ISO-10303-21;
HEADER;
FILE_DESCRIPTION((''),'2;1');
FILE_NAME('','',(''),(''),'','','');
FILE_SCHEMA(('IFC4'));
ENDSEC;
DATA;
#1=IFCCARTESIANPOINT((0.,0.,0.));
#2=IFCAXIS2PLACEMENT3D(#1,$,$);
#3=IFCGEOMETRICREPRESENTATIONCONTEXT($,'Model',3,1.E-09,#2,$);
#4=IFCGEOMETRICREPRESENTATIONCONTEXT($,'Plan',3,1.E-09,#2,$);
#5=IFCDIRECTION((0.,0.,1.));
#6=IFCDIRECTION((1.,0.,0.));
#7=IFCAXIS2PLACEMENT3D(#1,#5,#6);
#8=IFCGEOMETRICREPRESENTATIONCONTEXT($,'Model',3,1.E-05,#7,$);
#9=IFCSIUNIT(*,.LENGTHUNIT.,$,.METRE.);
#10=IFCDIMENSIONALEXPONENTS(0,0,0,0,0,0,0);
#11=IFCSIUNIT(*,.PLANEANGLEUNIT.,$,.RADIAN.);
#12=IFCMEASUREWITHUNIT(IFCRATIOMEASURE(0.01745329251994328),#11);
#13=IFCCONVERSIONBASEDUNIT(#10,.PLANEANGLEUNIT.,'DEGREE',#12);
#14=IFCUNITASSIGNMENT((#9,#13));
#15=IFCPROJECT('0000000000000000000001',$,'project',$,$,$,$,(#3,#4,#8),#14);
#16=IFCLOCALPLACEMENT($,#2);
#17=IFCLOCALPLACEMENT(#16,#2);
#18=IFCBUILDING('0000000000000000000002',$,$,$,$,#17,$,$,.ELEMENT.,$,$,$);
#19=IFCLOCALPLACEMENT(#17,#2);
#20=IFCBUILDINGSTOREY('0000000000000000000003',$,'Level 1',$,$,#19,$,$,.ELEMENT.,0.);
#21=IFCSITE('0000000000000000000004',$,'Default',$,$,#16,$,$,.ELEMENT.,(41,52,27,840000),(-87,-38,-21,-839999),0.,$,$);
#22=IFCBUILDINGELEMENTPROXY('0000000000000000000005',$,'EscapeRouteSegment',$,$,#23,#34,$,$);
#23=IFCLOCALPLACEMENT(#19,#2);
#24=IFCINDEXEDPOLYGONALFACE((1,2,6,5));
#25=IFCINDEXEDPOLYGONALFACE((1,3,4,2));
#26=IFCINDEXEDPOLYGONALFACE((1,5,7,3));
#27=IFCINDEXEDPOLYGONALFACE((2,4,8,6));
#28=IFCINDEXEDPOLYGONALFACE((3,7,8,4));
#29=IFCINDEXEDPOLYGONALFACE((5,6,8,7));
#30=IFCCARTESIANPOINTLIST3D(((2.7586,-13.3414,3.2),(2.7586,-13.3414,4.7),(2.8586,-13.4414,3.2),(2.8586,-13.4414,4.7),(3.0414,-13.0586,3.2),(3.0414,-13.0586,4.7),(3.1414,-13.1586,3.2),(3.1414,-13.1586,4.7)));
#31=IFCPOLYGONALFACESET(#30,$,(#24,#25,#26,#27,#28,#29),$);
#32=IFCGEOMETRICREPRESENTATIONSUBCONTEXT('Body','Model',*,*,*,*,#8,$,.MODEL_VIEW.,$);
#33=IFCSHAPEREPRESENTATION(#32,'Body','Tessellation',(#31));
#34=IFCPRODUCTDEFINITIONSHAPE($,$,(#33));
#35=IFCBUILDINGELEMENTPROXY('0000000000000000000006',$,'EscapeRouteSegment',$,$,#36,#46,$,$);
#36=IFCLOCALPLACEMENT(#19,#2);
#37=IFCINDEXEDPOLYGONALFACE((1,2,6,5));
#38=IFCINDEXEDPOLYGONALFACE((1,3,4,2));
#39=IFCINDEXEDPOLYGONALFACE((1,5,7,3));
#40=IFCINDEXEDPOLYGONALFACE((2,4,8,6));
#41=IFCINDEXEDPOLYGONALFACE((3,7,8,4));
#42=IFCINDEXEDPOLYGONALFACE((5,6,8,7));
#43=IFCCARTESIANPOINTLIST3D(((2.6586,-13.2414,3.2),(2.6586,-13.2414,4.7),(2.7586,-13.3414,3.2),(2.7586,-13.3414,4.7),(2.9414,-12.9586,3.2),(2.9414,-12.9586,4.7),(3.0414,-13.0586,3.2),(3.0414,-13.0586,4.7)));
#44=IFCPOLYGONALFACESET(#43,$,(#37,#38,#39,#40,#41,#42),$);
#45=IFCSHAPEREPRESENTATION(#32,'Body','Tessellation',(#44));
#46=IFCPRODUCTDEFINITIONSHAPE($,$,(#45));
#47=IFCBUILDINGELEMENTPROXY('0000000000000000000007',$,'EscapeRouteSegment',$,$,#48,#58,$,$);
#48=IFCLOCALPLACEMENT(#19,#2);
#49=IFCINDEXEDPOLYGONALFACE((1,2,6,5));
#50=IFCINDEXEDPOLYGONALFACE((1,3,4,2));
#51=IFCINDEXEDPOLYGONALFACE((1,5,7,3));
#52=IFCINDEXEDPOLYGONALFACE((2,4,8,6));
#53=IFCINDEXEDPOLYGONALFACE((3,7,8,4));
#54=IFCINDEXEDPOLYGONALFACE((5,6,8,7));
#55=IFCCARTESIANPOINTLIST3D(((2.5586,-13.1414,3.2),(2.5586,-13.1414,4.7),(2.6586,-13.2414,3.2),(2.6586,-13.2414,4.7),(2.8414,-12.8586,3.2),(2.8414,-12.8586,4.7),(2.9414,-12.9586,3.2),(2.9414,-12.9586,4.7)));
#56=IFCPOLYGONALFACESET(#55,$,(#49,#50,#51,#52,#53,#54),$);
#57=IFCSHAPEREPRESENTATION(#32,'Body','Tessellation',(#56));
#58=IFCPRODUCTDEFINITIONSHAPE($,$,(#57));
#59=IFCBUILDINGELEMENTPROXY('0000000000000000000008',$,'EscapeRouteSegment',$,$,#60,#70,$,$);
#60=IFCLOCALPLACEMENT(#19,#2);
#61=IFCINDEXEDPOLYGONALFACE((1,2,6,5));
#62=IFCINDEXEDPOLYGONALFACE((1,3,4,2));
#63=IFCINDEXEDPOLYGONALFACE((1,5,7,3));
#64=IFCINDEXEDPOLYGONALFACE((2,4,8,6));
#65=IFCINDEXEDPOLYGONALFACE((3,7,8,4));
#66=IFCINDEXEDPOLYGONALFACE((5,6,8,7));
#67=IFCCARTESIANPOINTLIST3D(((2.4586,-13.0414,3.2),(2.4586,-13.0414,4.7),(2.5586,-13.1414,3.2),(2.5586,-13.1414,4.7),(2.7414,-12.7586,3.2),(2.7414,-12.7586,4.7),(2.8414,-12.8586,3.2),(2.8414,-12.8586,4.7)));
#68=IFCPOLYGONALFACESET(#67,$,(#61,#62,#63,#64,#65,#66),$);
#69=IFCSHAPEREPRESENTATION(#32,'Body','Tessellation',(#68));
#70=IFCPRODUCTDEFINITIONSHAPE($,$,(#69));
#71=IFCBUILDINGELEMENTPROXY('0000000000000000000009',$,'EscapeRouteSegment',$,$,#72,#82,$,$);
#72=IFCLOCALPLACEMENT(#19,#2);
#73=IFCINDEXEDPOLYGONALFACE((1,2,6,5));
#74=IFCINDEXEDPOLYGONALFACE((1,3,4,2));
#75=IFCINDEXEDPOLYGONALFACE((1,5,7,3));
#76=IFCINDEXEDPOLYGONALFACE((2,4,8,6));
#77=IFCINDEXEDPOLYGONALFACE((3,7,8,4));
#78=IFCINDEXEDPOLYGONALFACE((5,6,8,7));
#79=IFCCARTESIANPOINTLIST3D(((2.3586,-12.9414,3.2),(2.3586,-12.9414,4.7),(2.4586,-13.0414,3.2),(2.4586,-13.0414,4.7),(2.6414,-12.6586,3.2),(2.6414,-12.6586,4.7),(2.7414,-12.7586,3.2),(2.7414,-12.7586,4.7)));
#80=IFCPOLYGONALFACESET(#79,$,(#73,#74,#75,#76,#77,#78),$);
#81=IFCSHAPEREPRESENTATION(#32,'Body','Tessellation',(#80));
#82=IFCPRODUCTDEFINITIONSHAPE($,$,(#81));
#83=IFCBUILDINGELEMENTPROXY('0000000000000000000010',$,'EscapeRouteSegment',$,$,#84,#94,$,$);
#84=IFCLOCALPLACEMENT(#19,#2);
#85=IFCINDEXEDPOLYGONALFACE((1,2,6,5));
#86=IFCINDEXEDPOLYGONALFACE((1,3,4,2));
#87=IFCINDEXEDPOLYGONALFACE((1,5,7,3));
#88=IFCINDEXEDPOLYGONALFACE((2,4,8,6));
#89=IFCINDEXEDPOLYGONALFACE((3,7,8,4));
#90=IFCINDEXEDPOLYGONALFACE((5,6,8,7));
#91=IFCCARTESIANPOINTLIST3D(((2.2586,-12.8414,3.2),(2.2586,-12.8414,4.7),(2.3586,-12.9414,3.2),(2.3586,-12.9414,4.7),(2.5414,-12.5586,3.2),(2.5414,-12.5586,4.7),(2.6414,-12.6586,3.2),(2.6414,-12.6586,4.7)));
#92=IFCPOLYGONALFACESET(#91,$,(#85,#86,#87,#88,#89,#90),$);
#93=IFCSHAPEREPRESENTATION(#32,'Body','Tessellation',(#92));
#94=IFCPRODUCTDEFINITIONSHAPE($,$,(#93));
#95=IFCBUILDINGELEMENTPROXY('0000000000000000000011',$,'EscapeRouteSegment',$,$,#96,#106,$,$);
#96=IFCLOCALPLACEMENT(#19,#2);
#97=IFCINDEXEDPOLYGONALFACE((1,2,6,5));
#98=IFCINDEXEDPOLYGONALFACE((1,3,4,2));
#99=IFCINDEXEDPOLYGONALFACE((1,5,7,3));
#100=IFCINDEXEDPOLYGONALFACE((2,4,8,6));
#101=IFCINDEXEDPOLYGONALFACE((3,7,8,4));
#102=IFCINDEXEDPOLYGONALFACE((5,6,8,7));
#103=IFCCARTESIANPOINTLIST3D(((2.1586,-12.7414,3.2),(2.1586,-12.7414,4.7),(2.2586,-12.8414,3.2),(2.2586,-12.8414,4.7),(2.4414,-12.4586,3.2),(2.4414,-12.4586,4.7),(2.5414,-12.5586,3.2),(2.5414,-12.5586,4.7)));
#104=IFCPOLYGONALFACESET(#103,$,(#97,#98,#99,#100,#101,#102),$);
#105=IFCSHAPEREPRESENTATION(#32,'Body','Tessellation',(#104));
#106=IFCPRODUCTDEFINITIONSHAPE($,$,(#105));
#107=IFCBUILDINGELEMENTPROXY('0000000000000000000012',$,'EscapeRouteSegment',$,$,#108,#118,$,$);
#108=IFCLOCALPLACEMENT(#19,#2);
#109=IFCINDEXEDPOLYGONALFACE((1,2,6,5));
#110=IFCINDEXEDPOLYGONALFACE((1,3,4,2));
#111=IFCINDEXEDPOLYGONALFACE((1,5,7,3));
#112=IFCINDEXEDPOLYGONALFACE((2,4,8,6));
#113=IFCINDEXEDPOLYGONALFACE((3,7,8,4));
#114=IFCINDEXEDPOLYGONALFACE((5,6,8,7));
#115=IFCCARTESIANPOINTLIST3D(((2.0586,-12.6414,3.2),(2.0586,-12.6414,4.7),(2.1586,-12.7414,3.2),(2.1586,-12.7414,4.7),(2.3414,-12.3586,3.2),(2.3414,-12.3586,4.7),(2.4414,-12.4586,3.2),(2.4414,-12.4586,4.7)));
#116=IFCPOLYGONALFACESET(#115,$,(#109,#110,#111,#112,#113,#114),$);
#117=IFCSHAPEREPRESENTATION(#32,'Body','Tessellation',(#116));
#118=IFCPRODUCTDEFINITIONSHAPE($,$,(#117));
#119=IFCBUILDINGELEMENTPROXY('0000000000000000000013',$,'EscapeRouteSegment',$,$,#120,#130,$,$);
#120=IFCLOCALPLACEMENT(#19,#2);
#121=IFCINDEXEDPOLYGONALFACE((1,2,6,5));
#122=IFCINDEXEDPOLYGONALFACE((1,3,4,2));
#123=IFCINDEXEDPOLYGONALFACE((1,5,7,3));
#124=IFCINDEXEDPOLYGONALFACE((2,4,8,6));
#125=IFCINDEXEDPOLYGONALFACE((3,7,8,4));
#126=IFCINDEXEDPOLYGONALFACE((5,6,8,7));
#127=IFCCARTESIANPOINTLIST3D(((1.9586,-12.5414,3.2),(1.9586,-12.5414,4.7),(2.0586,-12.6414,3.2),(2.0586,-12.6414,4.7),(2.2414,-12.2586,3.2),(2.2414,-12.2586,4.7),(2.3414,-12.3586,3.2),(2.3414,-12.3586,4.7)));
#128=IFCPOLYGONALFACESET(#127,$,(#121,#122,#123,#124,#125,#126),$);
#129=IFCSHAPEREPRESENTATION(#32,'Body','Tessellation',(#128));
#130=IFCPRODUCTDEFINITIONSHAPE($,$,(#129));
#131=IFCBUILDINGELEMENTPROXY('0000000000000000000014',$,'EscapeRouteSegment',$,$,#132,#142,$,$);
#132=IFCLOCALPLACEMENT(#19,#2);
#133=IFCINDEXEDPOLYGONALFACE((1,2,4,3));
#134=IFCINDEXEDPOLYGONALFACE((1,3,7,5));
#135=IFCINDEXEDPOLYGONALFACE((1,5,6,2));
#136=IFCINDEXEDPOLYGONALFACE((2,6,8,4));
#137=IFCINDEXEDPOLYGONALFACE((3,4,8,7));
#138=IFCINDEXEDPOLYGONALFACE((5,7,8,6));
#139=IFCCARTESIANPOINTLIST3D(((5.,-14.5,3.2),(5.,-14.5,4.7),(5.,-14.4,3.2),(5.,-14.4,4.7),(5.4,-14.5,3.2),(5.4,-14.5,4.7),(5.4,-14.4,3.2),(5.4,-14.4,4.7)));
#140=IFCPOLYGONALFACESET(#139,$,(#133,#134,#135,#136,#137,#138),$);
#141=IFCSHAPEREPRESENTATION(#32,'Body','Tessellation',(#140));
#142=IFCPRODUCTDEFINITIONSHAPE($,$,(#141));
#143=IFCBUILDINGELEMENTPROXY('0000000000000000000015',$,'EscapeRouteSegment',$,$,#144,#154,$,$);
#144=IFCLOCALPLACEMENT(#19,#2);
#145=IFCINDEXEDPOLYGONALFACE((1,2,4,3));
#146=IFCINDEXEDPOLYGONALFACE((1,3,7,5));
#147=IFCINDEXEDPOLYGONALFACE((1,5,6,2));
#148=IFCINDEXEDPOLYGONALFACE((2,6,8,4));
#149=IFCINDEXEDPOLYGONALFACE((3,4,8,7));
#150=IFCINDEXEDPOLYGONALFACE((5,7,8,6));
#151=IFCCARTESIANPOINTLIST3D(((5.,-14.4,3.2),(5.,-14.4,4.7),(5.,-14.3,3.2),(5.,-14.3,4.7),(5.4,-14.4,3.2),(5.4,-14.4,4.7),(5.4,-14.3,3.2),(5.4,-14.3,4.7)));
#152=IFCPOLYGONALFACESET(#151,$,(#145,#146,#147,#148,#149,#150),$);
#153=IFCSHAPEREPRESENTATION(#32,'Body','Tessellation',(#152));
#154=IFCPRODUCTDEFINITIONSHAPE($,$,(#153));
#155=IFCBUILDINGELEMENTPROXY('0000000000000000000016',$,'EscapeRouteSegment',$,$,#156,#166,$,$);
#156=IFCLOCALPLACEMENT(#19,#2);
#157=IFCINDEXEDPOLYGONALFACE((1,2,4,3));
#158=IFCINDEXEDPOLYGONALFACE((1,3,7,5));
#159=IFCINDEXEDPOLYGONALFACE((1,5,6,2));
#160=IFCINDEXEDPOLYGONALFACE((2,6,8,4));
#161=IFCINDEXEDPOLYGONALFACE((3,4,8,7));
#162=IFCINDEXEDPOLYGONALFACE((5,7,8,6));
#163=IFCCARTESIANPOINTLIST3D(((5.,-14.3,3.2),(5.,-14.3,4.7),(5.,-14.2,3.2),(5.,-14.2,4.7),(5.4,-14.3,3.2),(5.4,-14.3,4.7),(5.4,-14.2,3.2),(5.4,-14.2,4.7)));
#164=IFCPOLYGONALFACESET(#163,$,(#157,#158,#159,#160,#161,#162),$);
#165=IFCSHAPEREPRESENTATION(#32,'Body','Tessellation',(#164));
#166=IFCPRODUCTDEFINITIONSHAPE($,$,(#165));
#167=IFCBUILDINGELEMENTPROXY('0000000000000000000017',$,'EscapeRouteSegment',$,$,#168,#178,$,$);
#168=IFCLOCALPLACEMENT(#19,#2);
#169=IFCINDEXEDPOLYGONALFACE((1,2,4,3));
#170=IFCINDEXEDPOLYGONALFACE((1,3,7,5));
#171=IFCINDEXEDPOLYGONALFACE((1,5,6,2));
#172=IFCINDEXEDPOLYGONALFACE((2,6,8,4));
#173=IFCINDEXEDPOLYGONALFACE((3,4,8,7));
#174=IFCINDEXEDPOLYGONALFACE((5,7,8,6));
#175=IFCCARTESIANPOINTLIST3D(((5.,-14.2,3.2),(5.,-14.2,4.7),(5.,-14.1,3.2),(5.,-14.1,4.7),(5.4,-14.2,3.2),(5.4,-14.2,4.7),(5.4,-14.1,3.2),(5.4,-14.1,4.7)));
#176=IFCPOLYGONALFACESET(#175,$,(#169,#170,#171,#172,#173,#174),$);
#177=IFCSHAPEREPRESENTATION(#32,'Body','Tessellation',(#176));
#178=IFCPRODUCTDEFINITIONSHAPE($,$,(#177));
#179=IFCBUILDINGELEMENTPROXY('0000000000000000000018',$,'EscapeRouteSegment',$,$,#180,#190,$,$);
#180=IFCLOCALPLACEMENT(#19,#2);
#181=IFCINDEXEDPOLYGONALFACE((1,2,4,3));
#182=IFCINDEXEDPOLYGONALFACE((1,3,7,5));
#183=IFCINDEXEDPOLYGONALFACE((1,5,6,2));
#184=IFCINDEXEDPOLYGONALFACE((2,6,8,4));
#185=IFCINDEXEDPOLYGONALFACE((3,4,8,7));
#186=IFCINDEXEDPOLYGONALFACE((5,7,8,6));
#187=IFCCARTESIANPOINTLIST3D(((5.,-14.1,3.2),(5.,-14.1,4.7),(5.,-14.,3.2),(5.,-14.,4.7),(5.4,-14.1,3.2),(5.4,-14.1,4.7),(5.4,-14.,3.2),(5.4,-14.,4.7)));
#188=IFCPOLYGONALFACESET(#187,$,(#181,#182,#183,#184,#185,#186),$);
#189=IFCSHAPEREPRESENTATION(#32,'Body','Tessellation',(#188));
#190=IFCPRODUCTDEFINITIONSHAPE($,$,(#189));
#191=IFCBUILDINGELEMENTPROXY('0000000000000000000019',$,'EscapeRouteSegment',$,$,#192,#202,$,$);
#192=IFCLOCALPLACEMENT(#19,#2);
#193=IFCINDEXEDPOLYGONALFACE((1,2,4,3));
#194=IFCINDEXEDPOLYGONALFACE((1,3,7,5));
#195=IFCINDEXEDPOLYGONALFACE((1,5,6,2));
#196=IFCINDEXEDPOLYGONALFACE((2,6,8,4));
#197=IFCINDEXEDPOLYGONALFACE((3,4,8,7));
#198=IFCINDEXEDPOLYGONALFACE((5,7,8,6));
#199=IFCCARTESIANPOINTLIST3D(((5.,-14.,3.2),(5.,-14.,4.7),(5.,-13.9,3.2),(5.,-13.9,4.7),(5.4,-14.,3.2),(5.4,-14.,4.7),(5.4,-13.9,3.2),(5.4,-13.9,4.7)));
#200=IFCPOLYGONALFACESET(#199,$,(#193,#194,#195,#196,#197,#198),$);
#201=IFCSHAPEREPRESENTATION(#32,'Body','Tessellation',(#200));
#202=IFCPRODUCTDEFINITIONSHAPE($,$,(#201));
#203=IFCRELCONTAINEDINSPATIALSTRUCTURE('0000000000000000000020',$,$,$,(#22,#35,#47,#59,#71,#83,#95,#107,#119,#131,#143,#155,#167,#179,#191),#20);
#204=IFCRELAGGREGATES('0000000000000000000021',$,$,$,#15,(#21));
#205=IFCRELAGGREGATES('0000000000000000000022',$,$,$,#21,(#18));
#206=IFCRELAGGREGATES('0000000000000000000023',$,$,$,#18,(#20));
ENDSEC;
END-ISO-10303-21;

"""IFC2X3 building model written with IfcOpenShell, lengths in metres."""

from ifc_helpers import new_model, entity, si_unit, converted_unit, frame, origin, origin_with_axes, place, context, subcontext, project, spatial, polyline, outline, extrude, element, save


model = new_model("IFC2X3")

# Units and contexts
model_context_1 = context("Model", 3, precision=1e-09, world=origin())
plan_context = context("Plan", 3, precision=1e-09, world=origin())
model_context_2 = context("Model", 3, precision=1e-05, world=origin_with_axes())
body_context = subcontext(model_context_2, "Body", "Model", "MODEL_VIEW")
ifc_project = project(units=[si_unit("LENGTHUNIT", "METRE"), converted_unit("PLANEANGLEUNIT", "DEGREE", entity("IfcRatioMeasure", 0.01745329251994328), si_unit("PLANEANGLEUNIT", "RADIAN"), dimensions=[0, 0, 0, 0, 0, 0, 0])], contexts=[model_context_1, plan_context, model_context_2])

# Site, building, storey
site_placement = place(None, origin())
site = spatial("IfcSite", under=ifc_project, at=site_placement, Name="Default", CompositionType="ELEMENT", RefLatitude=(41, 52, 27, 840000), RefLongitude=(-87, -38, -21, -839999), RefElevation=0.0)
building_placement = place(site_placement, origin())
building = spatial("IfcBuilding", under=site, at=building_placement, CompositionType="ELEMENT")
storey_placement = place(building_placement, origin())
storey = spatial("IfcBuildingStorey", under=building, at=storey_placement, Name="Level 1", CompositionType="ELEMENT", Elevation=0.0)

# Building element proxies
proxy_1_placement = place(storey_placement, frame((3.0, -13.3, 3.2), z_axis=(0.0, 0.0, 1.0), x_axis=(-0.707105, 0.707108, 0.0)))
element("IfcBuildingElementProxy", 1, at=proxy_1_placement, inside=storey, Name="EscapeRouteSegment", context=body_context, shape_type="SweptSolid", body=[
    extrude(outline(polyline([(0.0, -0.2), (0.0, 0.2), (0.1414, 0.2), (0.1414, -0.2), (0.0, -0.2)])), origin_with_axes(), (0.0, 0.0, 1.0), 1.5),
])
proxy_2_placement = place(storey_placement, frame((2.9, -13.2, 3.2), z_axis=(0.0, 0.0, 1.0), x_axis=(-0.707109, 0.707104, 0.0)))
element("IfcBuildingElementProxy", 2, at=proxy_2_placement, inside=storey, Name="EscapeRouteSegment", context=body_context, shape_type="SweptSolid", body=[
    extrude(outline(polyline([(0.0, -0.2), (0.0, 0.2), (0.1414, 0.2), (0.1414, -0.2), (0.0, -0.2)])), origin_with_axes(), (0.0, 0.0, 1.0), 1.5),
])
proxy_3_placement = place(storey_placement, frame((2.8, -13.1, 3.2), z_axis=(0.0, 0.0, 1.0), x_axis=(-0.707105, 0.707108, 0.0)))
element("IfcBuildingElementProxy", 3, at=proxy_3_placement, inside=storey, Name="EscapeRouteSegment", context=body_context, shape_type="SweptSolid", body=[
    extrude(outline(polyline([(0.0, -0.2), (0.0, 0.2), (0.1414, 0.2), (0.1414, -0.2), (0.0, -0.2)])), origin_with_axes(), (0.0, 0.0, 1.0), 1.5),
])
proxy_4_placement = place(storey_placement, frame((2.7, -13.0, 3.2), z_axis=(0.0, 0.0, 1.0), x_axis=(-0.707106, 0.707108, 0.0)))
element("IfcBuildingElementProxy", 4, at=proxy_4_placement, inside=storey, Name="EscapeRouteSegment", context=body_context, shape_type="SweptSolid", body=[
    extrude(outline(polyline([(0.0, -0.2), (0.0, 0.2), (0.1414, 0.2), (0.1414, -0.2), (0.0, -0.2)])), origin_with_axes(), (0.0, 0.0, 1.0), 1.5),
])
proxy_5_placement = place(storey_placement, frame((2.6, -12.9, 3.2), z_axis=(0.0, 0.0, 1.0), x_axis=(-0.707108, 0.707105, 0.0)))
element("IfcBuildingElementProxy", 5, at=proxy_5_placement, inside=storey, Name="EscapeRouteSegment", context=body_context, shape_type="SweptSolid", body=[
    extrude(outline(polyline([(0.0, -0.2), (0.0, 0.2), (0.1414, 0.2), (0.1414, -0.2), (0.0, -0.2)])), origin_with_axes(), (0.0, 0.0, 1.0), 1.5),
])
proxy_6_placement = place(storey_placement, frame((2.5, -12.8, 3.2), z_axis=(0.0, 0.0, 1.0), x_axis=(-0.707105, 0.707108, 0.0)))
element("IfcBuildingElementProxy", 6, at=proxy_6_placement, inside=storey, Name="EscapeRouteSegment", context=body_context, shape_type="SweptSolid", body=[
    extrude(outline(polyline([(0.0, -0.2), (0.0, 0.2), (0.1414, 0.2), (0.1414, -0.2), (0.0, -0.2)])), origin_with_axes(), (0.0, 0.0, 1.0), 1.5),
])
proxy_7_placement = place(storey_placement, frame((2.4, -12.7, 3.2), z_axis=(0.0, 0.0, 1.0), x_axis=(-0.707109, 0.707104, 0.0)))
element("IfcBuildingElementProxy", 7, at=proxy_7_placement, inside=storey, Name="EscapeRouteSegment", context=body_context, shape_type="SweptSolid", body=[
    extrude(outline(polyline([(0.0, -0.2), (0.0, 0.2), (0.1414, 0.2), (0.1414, -0.2), (0.0, -0.2)])), origin_with_axes(), (0.0, 0.0, 1.0), 1.5),
])
proxy_8_placement = place(storey_placement, frame((2.3, -12.6, 3.2), z_axis=(0.0, 0.0, 1.0), x_axis=(-0.707105, 0.707108, 0.0)))
element("IfcBuildingElementProxy", 8, at=proxy_8_placement, inside=storey, Name="EscapeRouteSegment", context=body_context, shape_type="SweptSolid", body=[
    extrude(outline(polyline([(0.0, -0.2), (0.0, 0.2), (0.1414, 0.2), (0.1414, -0.2), (0.0, -0.2)])), origin_with_axes(), (0.0, 0.0, 1.0), 1.5),
])
proxy_9_placement = place(storey_placement, frame((2.2, -12.5, 3.2), z_axis=(0.0, 0.0, 1.0), x_axis=(-0.707106, 0.707108, 0.0)))
element("IfcBuildingElementProxy", 9, at=proxy_9_placement, inside=storey, Name="EscapeRouteSegment", context=body_context, shape_type="SweptSolid", body=[
    extrude(outline(polyline([(0.0, -0.2), (0.0, 0.2), (0.1414, 0.2), (0.1414, -0.2), (0.0, -0.2)])), origin_with_axes(), (0.0, 0.0, 1.0), 1.5),
])
proxy_10_placement = place(storey_placement, frame((5.2, -14.5, 3.2), z_axis=(0.0, 0.0, 1.0), x_axis=(0.0, 1.0, 0.0)))
element("IfcBuildingElementProxy", 10, at=proxy_10_placement, inside=storey, Name="EscapeRouteSegment", context=body_context, shape_type="SweptSolid", body=[
    extrude(outline(polyline([(0.0, -0.2), (0.0, 0.2), (0.1, 0.2), (0.1, -0.2), (0.0, -0.2)])), origin_with_axes(), (0.0, 0.0, 1.0), 1.5),
])
proxy_11_placement = place(storey_placement, frame((5.2, -14.4, 3.2), z_axis=(0.0, 0.0, 1.0), x_axis=(0.0, 1.0, 0.0)))
element("IfcBuildingElementProxy", 11, at=proxy_11_placement, inside=storey, Name="EscapeRouteSegment", context=body_context, shape_type="SweptSolid", body=[
    extrude(outline(polyline([(0.0, -0.2), (0.0, 0.2), (0.1, 0.2), (0.1, -0.2), (0.0, -0.2)])), origin_with_axes(), (0.0, 0.0, 1.0), 1.5),
])
proxy_12_placement = place(storey_placement, frame((5.2, -14.3, 3.2), z_axis=(0.0, 0.0, 1.0), x_axis=(0.0, 1.0, 0.0)))
element("IfcBuildingElementProxy", 12, at=proxy_12_placement, inside=storey, Name="EscapeRouteSegment", context=body_context, shape_type="SweptSolid", body=[
    extrude(outline(polyline([(0.0, -0.2), (0.0, 0.2), (0.1, 0.2), (0.1, -0.2), (0.0, -0.2)])), origin_with_axes(), (0.0, 0.0, 1.0), 1.5),
])
proxy_13_placement = place(storey_placement, frame((5.2, -14.2, 3.2), z_axis=(0.0, 0.0, 1.0), x_axis=(0.0, 1.0, 0.0)))
element("IfcBuildingElementProxy", 13, at=proxy_13_placement, inside=storey, Name="EscapeRouteSegment", context=body_context, shape_type="SweptSolid", body=[
    extrude(outline(polyline([(0.0, -0.2), (0.0, 0.2), (0.1, 0.2), (0.1, -0.2), (0.0, -0.2)])), origin_with_axes(), (0.0, 0.0, 1.0), 1.5),
])
for number, where, z_axis, x_axis, name in (
    (14, (5.2, -14.1, 3.2), (0.0, 0.0, 1.0), (0.0, 1.0, 0.0), "EscapeRouteSegment"),
    (15, (5.2, -14.0, 3.2), (0.0, 0.0, 1.0), (0.0, 1.0, 0.0), "EscapeRouteSegment"),
):
    element("IfcBuildingElementProxy", number, at=place(storey_placement, frame(where, z_axis=z_axis, x_axis=x_axis)), inside=storey, Name=name, context=body_context, shape_type="SweptSolid", body=[
        extrude(outline(polyline([(0.0, -0.2), (0.0, 0.2), (0.1, 0.2), (0.1, -0.2), (0.0, -0.2)])), origin_with_axes(), (0.0, 0.0, 1.0), 1.5),
    ])

save(model, "model.ifc")
